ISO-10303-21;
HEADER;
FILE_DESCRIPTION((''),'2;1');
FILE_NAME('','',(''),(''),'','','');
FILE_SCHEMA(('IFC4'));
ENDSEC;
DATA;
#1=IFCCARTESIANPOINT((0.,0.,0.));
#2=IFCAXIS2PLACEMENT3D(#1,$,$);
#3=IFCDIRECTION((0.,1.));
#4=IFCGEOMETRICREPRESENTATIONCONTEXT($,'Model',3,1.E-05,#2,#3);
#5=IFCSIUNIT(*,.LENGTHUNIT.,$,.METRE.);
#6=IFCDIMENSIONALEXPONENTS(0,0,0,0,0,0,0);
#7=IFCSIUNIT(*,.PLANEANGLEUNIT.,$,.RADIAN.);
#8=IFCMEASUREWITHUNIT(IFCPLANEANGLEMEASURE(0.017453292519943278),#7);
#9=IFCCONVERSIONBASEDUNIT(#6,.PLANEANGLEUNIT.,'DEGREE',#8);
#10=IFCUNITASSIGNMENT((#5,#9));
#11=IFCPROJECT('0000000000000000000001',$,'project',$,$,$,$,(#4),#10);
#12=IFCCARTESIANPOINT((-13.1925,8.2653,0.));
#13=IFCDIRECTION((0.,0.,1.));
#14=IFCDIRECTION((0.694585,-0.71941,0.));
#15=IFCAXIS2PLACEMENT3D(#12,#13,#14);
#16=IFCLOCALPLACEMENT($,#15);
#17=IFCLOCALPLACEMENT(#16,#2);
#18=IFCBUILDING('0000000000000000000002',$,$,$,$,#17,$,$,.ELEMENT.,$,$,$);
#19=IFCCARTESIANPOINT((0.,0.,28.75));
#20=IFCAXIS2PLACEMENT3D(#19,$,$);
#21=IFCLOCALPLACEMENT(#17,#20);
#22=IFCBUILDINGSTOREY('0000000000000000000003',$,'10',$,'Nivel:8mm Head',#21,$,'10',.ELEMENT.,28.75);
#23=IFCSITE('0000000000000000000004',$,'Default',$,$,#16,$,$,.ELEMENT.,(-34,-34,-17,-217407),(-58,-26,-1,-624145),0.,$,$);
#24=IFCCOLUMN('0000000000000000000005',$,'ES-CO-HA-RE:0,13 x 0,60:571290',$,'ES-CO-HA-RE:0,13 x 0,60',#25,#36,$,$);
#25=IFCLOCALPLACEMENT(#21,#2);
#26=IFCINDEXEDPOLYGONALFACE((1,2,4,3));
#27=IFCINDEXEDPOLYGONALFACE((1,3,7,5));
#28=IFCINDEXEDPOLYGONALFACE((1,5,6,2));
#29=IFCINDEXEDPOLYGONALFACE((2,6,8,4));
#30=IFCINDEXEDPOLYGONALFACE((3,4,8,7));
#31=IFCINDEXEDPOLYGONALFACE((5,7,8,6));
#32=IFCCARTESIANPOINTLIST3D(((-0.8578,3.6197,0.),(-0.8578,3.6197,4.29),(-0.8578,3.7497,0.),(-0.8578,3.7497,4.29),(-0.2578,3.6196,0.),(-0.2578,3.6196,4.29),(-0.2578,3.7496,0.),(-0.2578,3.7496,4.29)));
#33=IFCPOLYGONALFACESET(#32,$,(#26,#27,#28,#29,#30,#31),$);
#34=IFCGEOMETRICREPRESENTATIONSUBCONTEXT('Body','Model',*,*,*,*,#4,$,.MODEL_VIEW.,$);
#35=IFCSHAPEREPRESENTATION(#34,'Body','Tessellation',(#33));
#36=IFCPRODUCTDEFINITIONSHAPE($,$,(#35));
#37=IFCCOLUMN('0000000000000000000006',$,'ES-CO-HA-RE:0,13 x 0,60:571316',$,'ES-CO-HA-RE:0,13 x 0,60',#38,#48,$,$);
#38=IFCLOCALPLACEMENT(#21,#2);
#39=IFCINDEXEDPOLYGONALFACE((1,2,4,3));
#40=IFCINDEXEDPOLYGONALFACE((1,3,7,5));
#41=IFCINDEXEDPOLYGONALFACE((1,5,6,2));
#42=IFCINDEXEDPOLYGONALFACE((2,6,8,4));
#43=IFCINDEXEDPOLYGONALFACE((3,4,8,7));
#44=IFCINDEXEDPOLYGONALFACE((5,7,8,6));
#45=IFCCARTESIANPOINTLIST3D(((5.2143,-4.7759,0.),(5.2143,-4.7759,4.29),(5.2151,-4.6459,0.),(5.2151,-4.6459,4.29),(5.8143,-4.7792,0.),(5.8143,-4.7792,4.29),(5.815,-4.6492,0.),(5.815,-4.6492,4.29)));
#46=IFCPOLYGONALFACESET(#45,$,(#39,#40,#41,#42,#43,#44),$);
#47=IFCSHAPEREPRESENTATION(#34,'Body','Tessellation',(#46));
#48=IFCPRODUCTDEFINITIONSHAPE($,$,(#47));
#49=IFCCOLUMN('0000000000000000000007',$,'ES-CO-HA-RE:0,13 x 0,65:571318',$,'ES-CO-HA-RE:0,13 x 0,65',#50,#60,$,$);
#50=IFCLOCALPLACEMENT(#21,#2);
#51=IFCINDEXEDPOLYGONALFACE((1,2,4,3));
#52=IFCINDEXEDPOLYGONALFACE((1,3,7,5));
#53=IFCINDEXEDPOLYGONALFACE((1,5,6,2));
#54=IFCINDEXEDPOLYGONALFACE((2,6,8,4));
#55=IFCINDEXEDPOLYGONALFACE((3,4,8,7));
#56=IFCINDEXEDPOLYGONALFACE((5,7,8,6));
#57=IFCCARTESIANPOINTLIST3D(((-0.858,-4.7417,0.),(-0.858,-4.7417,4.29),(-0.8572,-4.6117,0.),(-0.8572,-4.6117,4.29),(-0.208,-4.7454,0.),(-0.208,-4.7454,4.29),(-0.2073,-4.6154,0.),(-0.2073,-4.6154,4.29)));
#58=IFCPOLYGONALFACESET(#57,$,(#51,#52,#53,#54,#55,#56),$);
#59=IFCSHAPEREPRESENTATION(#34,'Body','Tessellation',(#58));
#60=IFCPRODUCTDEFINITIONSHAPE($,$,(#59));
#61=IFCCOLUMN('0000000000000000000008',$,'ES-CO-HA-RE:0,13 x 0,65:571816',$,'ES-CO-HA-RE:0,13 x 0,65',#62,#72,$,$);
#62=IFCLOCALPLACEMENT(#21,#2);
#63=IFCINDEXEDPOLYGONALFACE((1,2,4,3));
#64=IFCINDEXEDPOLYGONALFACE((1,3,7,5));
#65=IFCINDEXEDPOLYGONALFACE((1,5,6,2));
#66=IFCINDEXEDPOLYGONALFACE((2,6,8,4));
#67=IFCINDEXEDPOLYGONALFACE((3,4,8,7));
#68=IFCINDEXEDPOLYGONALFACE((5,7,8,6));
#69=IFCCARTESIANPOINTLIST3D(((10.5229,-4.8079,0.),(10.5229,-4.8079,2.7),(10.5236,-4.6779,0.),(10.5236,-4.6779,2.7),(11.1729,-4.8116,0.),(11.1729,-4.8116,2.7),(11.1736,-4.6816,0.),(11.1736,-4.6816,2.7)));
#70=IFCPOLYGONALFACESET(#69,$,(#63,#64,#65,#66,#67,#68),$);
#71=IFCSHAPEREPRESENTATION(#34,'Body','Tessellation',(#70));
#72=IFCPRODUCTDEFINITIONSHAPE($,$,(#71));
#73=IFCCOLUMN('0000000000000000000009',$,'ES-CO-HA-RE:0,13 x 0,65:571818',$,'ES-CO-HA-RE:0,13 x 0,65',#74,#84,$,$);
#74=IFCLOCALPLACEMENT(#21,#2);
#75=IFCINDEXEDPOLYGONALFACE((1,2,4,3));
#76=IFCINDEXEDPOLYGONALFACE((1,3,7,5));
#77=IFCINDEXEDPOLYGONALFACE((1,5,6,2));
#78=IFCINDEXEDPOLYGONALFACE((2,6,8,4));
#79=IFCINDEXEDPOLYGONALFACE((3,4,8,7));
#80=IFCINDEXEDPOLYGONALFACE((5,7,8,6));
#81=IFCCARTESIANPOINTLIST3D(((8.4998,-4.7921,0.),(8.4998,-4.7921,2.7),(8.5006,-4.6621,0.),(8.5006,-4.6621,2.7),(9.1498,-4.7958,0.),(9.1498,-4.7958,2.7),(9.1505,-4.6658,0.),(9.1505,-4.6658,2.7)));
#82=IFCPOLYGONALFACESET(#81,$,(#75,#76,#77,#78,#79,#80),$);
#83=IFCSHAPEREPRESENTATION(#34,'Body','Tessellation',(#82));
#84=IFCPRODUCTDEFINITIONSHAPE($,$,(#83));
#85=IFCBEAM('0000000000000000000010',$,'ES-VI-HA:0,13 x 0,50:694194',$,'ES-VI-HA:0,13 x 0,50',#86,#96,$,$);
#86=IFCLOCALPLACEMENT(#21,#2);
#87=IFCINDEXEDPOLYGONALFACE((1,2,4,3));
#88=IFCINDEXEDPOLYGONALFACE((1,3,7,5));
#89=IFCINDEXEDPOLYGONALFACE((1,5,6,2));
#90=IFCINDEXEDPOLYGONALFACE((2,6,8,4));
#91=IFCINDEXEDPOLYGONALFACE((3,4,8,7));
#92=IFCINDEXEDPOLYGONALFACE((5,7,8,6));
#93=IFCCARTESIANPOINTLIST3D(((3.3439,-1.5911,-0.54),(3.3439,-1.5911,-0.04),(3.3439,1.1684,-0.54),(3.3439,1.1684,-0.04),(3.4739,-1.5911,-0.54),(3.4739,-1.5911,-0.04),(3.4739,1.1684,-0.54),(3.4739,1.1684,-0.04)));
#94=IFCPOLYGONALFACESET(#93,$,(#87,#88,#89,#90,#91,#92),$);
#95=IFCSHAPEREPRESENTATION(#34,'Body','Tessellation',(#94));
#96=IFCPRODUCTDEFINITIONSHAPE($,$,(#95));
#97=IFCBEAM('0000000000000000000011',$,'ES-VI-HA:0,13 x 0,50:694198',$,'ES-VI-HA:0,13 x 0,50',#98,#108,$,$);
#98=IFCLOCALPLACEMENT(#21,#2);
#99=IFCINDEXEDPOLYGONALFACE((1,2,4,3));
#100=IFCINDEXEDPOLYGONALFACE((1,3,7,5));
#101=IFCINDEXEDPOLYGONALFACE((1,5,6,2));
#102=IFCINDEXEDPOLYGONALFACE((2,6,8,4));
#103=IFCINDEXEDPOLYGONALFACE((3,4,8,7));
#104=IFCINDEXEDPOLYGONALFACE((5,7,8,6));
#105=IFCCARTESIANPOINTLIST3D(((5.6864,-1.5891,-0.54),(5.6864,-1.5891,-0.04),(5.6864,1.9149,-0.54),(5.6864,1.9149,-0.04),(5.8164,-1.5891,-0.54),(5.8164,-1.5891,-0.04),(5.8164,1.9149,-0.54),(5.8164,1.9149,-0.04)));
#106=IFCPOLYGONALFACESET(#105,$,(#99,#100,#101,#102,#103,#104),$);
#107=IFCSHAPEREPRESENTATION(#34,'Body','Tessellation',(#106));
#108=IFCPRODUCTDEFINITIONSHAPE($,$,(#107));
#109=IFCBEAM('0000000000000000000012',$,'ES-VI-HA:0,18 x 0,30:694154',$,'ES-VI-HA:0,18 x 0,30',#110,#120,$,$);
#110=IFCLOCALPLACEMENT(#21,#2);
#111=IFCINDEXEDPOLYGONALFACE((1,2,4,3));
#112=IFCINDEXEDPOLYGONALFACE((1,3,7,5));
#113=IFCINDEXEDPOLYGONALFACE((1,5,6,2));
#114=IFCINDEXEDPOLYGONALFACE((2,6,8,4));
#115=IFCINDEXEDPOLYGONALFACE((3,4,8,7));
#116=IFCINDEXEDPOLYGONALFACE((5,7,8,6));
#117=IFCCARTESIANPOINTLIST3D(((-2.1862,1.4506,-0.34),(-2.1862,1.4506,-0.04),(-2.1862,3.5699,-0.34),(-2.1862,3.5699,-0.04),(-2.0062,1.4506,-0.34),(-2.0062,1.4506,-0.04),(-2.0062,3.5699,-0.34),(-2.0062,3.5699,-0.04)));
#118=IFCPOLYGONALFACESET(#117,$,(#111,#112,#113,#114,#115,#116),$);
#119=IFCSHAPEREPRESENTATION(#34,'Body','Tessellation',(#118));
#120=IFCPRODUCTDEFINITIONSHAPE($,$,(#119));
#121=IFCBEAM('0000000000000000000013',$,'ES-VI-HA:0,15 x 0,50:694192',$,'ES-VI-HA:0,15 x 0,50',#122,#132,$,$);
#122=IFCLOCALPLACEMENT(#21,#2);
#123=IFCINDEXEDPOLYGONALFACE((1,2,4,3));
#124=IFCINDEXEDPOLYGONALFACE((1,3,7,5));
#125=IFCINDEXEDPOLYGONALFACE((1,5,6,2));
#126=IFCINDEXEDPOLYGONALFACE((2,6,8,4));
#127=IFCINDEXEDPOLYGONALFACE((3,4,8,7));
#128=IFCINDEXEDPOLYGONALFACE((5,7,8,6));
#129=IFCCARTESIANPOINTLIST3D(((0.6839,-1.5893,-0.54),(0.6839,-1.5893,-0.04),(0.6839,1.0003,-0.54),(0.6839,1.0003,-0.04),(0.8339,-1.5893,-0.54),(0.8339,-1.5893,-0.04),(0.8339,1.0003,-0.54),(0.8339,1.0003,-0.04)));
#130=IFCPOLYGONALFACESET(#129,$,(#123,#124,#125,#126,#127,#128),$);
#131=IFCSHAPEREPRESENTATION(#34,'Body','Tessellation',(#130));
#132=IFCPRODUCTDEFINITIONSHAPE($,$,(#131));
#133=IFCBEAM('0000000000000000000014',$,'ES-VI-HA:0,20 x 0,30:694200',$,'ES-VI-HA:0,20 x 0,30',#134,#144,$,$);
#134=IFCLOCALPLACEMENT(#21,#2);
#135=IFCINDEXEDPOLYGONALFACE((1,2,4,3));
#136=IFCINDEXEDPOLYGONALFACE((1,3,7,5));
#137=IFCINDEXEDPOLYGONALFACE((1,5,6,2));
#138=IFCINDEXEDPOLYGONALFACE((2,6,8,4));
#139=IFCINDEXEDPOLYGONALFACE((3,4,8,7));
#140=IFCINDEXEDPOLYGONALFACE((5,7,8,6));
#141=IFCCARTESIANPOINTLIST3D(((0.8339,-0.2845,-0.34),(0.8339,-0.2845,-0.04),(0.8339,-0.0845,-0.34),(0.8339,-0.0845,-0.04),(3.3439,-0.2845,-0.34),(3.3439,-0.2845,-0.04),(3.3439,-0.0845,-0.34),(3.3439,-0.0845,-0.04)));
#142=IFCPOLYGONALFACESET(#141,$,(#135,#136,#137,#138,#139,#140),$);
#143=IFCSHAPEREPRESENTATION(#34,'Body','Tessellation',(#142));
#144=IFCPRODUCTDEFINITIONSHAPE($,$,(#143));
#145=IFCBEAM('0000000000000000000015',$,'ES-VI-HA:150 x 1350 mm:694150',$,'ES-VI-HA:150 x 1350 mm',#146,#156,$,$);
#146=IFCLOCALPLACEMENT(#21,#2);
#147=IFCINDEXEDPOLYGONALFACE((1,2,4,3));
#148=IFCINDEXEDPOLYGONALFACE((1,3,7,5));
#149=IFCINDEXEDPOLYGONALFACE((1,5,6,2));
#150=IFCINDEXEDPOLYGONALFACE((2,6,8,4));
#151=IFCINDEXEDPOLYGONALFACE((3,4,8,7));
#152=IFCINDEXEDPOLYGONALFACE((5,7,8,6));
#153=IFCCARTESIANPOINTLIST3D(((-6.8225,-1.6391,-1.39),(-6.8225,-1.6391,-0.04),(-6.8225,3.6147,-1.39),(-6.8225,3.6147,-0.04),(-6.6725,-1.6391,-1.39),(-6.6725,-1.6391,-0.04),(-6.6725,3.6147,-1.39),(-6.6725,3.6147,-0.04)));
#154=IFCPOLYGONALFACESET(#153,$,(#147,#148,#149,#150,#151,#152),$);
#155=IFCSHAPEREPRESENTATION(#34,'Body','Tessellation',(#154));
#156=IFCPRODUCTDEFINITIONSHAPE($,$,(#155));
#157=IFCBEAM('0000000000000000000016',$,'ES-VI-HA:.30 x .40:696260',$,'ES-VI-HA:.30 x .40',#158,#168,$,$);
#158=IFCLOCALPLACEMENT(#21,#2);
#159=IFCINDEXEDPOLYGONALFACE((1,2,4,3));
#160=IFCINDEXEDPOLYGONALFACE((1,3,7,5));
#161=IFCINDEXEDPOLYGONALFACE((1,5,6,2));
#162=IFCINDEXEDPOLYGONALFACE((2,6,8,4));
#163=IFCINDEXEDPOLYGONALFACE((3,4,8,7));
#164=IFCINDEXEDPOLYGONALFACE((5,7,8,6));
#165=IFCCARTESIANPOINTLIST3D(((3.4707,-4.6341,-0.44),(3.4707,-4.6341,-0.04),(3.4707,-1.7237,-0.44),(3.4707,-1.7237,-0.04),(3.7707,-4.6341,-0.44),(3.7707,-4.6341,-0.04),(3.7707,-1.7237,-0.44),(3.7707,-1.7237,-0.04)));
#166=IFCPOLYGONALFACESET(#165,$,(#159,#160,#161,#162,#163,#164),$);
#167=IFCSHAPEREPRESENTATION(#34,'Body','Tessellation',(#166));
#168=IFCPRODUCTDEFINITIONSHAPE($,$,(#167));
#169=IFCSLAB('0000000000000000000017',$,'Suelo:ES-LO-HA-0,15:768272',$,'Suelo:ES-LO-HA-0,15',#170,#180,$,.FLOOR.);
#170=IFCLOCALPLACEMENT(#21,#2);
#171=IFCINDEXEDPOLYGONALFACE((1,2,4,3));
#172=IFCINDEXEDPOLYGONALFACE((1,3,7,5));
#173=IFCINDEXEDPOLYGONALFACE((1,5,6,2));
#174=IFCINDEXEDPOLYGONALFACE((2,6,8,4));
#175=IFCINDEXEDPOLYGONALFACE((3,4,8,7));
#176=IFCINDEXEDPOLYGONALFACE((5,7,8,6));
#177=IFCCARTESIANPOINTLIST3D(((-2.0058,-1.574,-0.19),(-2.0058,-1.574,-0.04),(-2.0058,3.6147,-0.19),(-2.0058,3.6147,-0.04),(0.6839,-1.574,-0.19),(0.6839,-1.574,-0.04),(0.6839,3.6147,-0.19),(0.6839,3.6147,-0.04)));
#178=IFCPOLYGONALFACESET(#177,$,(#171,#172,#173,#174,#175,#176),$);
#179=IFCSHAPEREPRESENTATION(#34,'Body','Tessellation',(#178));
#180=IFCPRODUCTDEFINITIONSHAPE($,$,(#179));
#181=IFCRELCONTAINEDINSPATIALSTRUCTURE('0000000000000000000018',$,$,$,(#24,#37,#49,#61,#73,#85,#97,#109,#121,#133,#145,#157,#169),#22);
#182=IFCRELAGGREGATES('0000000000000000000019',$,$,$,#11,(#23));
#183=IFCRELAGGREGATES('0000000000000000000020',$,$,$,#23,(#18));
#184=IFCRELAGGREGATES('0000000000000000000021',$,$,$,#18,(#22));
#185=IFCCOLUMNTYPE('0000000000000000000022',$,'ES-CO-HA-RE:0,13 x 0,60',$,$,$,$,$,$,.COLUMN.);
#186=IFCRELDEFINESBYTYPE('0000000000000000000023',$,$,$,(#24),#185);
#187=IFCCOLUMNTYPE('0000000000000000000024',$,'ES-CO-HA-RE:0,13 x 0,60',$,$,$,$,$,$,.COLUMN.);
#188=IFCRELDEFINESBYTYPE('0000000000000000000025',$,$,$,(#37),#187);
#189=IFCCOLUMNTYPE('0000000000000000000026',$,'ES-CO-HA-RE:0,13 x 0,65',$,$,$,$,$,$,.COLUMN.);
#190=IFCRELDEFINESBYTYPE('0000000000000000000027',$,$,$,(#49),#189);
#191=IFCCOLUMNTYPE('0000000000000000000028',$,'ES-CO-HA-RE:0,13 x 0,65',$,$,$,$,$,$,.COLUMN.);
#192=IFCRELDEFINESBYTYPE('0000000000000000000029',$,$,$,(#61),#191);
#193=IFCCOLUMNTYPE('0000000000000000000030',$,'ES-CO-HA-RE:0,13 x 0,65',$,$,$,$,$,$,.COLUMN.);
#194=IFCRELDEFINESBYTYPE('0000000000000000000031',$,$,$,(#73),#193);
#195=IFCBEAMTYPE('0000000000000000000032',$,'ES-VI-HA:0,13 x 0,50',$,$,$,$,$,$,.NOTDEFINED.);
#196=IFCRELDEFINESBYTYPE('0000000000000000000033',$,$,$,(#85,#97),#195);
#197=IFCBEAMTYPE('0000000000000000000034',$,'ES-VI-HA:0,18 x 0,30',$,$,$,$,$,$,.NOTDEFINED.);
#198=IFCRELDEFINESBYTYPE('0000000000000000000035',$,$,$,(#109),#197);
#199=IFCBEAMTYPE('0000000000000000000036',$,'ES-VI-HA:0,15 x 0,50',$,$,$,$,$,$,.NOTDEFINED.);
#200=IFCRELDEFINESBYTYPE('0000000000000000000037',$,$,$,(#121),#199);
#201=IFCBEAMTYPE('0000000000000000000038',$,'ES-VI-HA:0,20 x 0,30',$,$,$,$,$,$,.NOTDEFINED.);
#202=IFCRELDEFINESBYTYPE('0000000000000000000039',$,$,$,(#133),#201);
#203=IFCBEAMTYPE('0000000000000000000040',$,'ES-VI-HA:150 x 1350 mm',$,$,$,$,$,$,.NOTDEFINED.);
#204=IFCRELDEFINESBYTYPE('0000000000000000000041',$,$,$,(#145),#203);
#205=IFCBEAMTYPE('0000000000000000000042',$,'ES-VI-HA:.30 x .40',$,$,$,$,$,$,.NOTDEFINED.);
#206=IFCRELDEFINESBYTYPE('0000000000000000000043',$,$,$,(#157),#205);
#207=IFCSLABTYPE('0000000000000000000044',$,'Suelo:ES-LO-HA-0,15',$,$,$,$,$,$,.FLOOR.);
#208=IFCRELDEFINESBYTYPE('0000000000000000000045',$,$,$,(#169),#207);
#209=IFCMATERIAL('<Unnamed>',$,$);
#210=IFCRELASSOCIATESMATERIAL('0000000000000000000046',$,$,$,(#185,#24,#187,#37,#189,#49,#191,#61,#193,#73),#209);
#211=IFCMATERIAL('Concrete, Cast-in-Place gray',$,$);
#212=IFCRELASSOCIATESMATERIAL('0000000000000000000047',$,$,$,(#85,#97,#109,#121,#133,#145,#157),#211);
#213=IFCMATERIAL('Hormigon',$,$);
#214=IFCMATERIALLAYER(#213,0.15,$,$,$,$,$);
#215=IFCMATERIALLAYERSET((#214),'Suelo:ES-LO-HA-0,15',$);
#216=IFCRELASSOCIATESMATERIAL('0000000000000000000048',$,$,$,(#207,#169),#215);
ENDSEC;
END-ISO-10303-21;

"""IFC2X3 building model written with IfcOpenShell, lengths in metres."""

from ifc_helpers import new_model, entity, si_unit, converted_unit, direction, frame, frame_2d, origin, origin_2d_with_axis, place, context, subcontext, project, spatial, rectangle, extrude, source, transform, mapped, material, layer, layer_set, layer_usage, type_object, type_shapes, element, save


model = new_model("IFC2X3")

# Units and contexts
model_context = context("Model", 3, precision=1e-05, world=origin(), true_north=direction((0.0, 1.0)))
body_context = subcontext(model_context, "Body", "Model", "MODEL_VIEW")
ifc_project = project(units=[si_unit("LENGTHUNIT", "METRE"), converted_unit("PLANEANGLEUNIT", "DEGREE", entity("IfcPlaneAngleMeasure", 0.017453292519943278), si_unit("PLANEANGLEUNIT", "RADIAN"), dimensions=[0, 0, 0, 0, 0, 0, 0])], contexts=[model_context])

# Site, building, storey
site_placement = place(None, frame((-13.1925, 8.2653, 0.0), z_axis=(0.0, 0.0, 1.0), x_axis=(0.694585, -0.71941, 0.0)))
site = spatial("IfcSite", under=ifc_project, at=site_placement, Name="Default", CompositionType="ELEMENT", RefLatitude=(-34, -34, -17, -217407), RefLongitude=(-58, -26, -1, -624145), RefElevation=0.0)
building_placement = place(site_placement, origin())
building = spatial("IfcBuilding", under=site, at=building_placement, CompositionType="ELEMENT")
storey_placement = place(building_placement, frame((0.0, 0.0, 28.75)))
storey = spatial("IfcBuildingStorey", under=building, at=storey_placement, Name="10", ObjectType="Nivel:8mm Head", LongName="10", CompositionType="ELEMENT", Elevation=28.75)

# Columns
ifc_material_1 = material(Name="<Unnamed>")
column_type_1 = type_object("IfcColumnType", Name="ES-CO-HA-RE:0,13 x 0,60", PredefinedType="COLUMN", material=ifc_material_1)
shared_shape_1 = source(origin(), body_context, "Body", "SweptSolid", [
    extrude(rectangle(XDim=0.6, YDim=0.13, at=frame_2d((0.0, 0.0), x_axis=(1.0, 0.0))), frame((-0.5578, 3.6847, 28.75), z_axis=(0.0, 0.0, 1.0), x_axis=(-1.0, 0.000006, 0.0)), (0.0, 0.0, 1.0), 4.29),
])
type_shapes(column_type_1, [shared_shape_1])
column_1_placement = place(storey_placement, frame((0.0, 0.0, -28.75)))
element("IfcColumn", 1, at=column_1_placement, inside=storey, type_object=column_type_1, material=ifc_material_1, Name="ES-CO-HA-RE:0,13 x 0,60:571290", ObjectType="ES-CO-HA-RE:0,13 x 0,60", context=body_context, shape_type="MappedRepresentation", body=[
    mapped(shared_shape_1, transform((0.0, 0.0, 0.0), scale=1.0)),
])
column_type_2 = type_object("IfcColumnType", Name="ES-CO-HA-RE:0,13 x 0,60", PredefinedType="COLUMN", material=ifc_material_1)
shared_shape_2 = source(origin(), body_context, "Body", "SweptSolid", [
    extrude(rectangle(XDim=0.6, YDim=0.13, at=frame_2d((0.0, 0.0), x_axis=(1.0, 0.0))), frame((5.5147, -4.7125, 28.75), z_axis=(0.0, 0.0, 1.0), x_axis=(-0.999984, 0.005619, 0.0)), (0.0, 0.0, 1.0), 4.29),
])
type_shapes(column_type_2, [shared_shape_2])
column_2_placement = place(storey_placement, frame((0.0, 0.0, -28.75)))
element("IfcColumn", 2, at=column_2_placement, inside=storey, type_object=column_type_2, material=ifc_material_1, Name="ES-CO-HA-RE:0,13 x 0,60:571316", ObjectType="ES-CO-HA-RE:0,13 x 0,60", context=body_context, shape_type="MappedRepresentation", body=[
    mapped(shared_shape_2, transform((0.0, 0.0, 0.0), scale=1.0)),
])
column_type_3 = type_object("IfcColumnType", Name="ES-CO-HA-RE:0,13 x 0,65", PredefinedType="COLUMN", material=ifc_material_1)
shared_shape_3 = source(origin(), body_context, "Body", "SweptSolid", [
    extrude(rectangle(XDim=0.65, YDim=0.13, at=frame_2d((0.0, 0.0), x_axis=(1.0, 0.0))), frame((-0.5326, -4.6786, 28.75), z_axis=(0.0, 0.0, 1.0), x_axis=(-0.999984, 0.005617, 0.0)), (0.0, 0.0, 1.0), 4.29),
])
type_shapes(column_type_3, [shared_shape_3])
column_3_placement = place(storey_placement, frame((0.0, 0.0, -28.75)))
element("IfcColumn", 3, at=column_3_placement, inside=storey, type_object=column_type_3, material=ifc_material_1, Name="ES-CO-HA-RE:0,13 x 0,65:571318", ObjectType="ES-CO-HA-RE:0,13 x 0,65", context=body_context, shape_type="MappedRepresentation", body=[
    mapped(shared_shape_3, transform((0.0, 0.0, 0.0), scale=1.0)),
])
column_type_4 = type_object("IfcColumnType", Name="ES-CO-HA-RE:0,13 x 0,65", PredefinedType="COLUMN", material=ifc_material_1)
shared_shape_4 = source(origin(), body_context, "Body", "SweptSolid", [
    extrude(rectangle(XDim=0.65, YDim=0.13, at=frame_2d((0.0, 0.0), x_axis=(1.0, 0.0))), frame((10.8483, -4.7447, 28.75), z_axis=(0.0, 0.0, 1.0), x_axis=(-0.999984, 0.005619, 0.0)), (0.0, 0.0, 1.0), 2.7),
])
type_shapes(column_type_4, [shared_shape_4])
column_4_placement = place(storey_placement, frame((0.0, 0.0, -28.75)))
element("IfcColumn", 4, at=column_4_placement, inside=storey, type_object=column_type_4, material=ifc_material_1, Name="ES-CO-HA-RE:0,13 x 0,65:571816", ObjectType="ES-CO-HA-RE:0,13 x 0,65", context=body_context, shape_type="MappedRepresentation", body=[
    mapped(shared_shape_4, transform((0.0, 0.0, 0.0), scale=1.0)),
])
column_type_5 = type_object("IfcColumnType", Name="ES-CO-HA-RE:0,13 x 0,65", PredefinedType="COLUMN", material=ifc_material_1)
shared_shape_5 = source(origin(), body_context, "Body", "SweptSolid", [
    extrude(rectangle(XDim=0.65, YDim=0.13, at=origin_2d_with_axis()), frame((8.8252, -4.7289, 28.75), z_axis=(0.0, 0.0, 1.0), x_axis=(-0.999984, 0.005619, 0.0)), (0.0, 0.0, 1.0), 2.7),
])
type_shapes(column_type_5, [shared_shape_5])
column_5_placement = place(storey_placement, frame((0.0, 0.0, -28.75)))
element("IfcColumn", 5, at=column_5_placement, inside=storey, type_object=column_type_5, material=ifc_material_1, Name="ES-CO-HA-RE:0,13 x 0,65:571818", ObjectType="ES-CO-HA-RE:0,13 x 0,65", context=body_context, shape_type="MappedRepresentation", body=[
    mapped(shared_shape_5, transform((0.0, 0.0, 0.0), scale=1.0)),
])

# Beams
ifc_material_2 = material(Name="Concrete, Cast-in-Place gray")
beam_type_1 = type_object("IfcBeamType", Name="ES-VI-HA:0,13 x 0,50", PredefinedType="NOTDEFINED")
beam_1_placement = place(storey_placement, frame((3.4089, -1.5916, -0.04), z_axis=(0.0, 0.0, 1.0), x_axis=(0.0, 1.0, 0.0)))
element("IfcBeam", 6, at=beam_1_placement, inside=storey, type_object=beam_type_1, material=ifc_material_2, Name="ES-VI-HA:0,13 x 0,50:694194", ObjectType="ES-VI-HA:0,13 x 0,50", context=body_context, shape_type="SweptSolid", body=[
    extrude(rectangle(XDim=0.5, YDim=0.13, at=frame_2d((0.0, 0.0), x_axis=(1.0, 0.0))), frame((0.0005, 0.0, -0.25), z_axis=(1.0, 0.0, 0.0), x_axis=(0.0, 0.0, -1.0)), (0.0, 0.0, 1.0), 2.7595),
])
beam_2_placement = place(storey_placement, frame((5.7514, -1.5891, -0.04), z_axis=(0.0, 0.0, 1.0), x_axis=(0.0, 1.0, 0.0)))
element("IfcBeam", 7, at=beam_2_placement, inside=storey, type_object=beam_type_1, material=ifc_material_2, Name="ES-VI-HA:0,13 x 0,50:694198", ObjectType="ES-VI-HA:0,13 x 0,50", context=body_context, shape_type="SweptSolid", body=[
    extrude(rectangle(XDim=0.5, YDim=0.13, at=frame_2d((0.0, 0.0), x_axis=(1.0, 0.0))), frame((0.0, 0.0, -0.25), z_axis=(1.0, 0.0, 0.0), x_axis=(0.0, 0.0, -1.0)), (0.0, 0.0, 1.0), 3.5039),
])
beam_type_2 = type_object("IfcBeamType", Name="ES-VI-HA:0,18 x 0,30", PredefinedType="NOTDEFINED")
beam_3_placement = place(storey_placement, frame((-2.0962, 3.5699, -0.04), z_axis=(0.0, 0.0, 1.0), x_axis=(0.0, -1.0, 0.0)))
element("IfcBeam", 8, at=beam_3_placement, inside=storey, type_object=beam_type_2, material=ifc_material_2, Name="ES-VI-HA:0,18 x 0,30:694154", ObjectType="ES-VI-HA:0,18 x 0,30", context=body_context, shape_type="SweptSolid", body=[
    extrude(rectangle(XDim=0.3, YDim=0.18, at=origin_2d_with_axis()), frame((0.0, 0.0, -0.15), z_axis=(1.0, 0.0, 0.0), x_axis=(0.0, 0.0, -1.0)), (0.0, 0.0, 1.0), 2.1193),
])
beam_type_3 = type_object("IfcBeamType", Name="ES-VI-HA:0,15 x 0,50", PredefinedType="NOTDEFINED")
beam_4_placement = place(storey_placement, frame((0.7589, -1.6543, -0.04), z_axis=(0.0, 0.0, 1.0), x_axis=(0.0, 1.0, 0.0)))
element("IfcBeam", 9, at=beam_4_placement, inside=storey, type_object=beam_type_3, material=ifc_material_2, Name="ES-VI-HA:0,15 x 0,50:694192", ObjectType="ES-VI-HA:0,15 x 0,50", context=body_context, shape_type="SweptSolid", body=[
    extrude(rectangle(XDim=0.5, YDim=0.15, at=frame_2d((0.0, 0.0), x_axis=(1.0, 0.0))), frame((0.065, 0.0, -0.25), z_axis=(1.0, 0.0, 0.0), x_axis=(0.0, 0.0, -1.0)), (0.0, 0.0, 1.0), 2.5896),
])
beam_type_4 = type_object("IfcBeamType", Name="ES-VI-HA:0,20 x 0,30", PredefinedType="NOTDEFINED")
beam_5_placement = place(storey_placement, frame((0.7589, -0.1845, -0.04)))
element("IfcBeam", 10, at=beam_5_placement, inside=storey, type_object=beam_type_4, material=ifc_material_2, Name="ES-VI-HA:0,20 x 0,30:694200", ObjectType="ES-VI-HA:0,20 x 0,30", context=body_context, shape_type="SweptSolid", body=[
    extrude(rectangle(XDim=0.3, YDim=0.2, at=frame_2d((0.0, 0.0), x_axis=(1.0, 0.0))), frame((0.075, 0.0, -0.15), z_axis=(1.0, 0.0, 0.0), x_axis=(0.0, 0.0, -1.0)), (0.0, 0.0, 1.0), 2.51),
])
beam_type_5 = type_object("IfcBeamType", Name="ES-VI-HA:150 x 1350 mm", PredefinedType="NOTDEFINED")
beam_6_placement = place(storey_placement, frame((-6.7475, -1.6391, -0.04), z_axis=(0.0, 0.0, 1.0), x_axis=(0.0, 1.0, 0.0)))
element("IfcBeam", 11, at=beam_6_placement, inside=storey, type_object=beam_type_5, material=ifc_material_2, Name="ES-VI-HA:150 x 1350 mm:694150", ObjectType="ES-VI-HA:150 x 1350 mm", context=body_context, shape_type="SweptSolid", body=[
    extrude(rectangle(XDim=1.35, YDim=0.15, at=frame_2d((0.0, 0.0), x_axis=(1.0, 0.0))), frame((0.0, 0.0, -0.675), z_axis=(1.0, 0.0, 0.0), x_axis=(0.0, 0.0, -1.0)), (0.0, 0.0, 1.0), 5.2537),
])
beam_type_6 = type_object("IfcBeamType", Name="ES-VI-HA:.30 x .40", PredefinedType="NOTDEFINED")
beam_7_placement = place(storey_placement, frame((3.6207, -4.7011, -0.04), z_axis=(0.0, 0.0, 1.0), x_axis=(0.0, 1.0, 0.0)))
element("IfcBeam", 12, at=beam_7_placement, inside=storey, type_object=beam_type_6, material=ifc_material_2, Name="ES-VI-HA:.30 x .40:696260", ObjectType="ES-VI-HA:.30 x .40", context=body_context, shape_type="SweptSolid", body=[
    extrude(rectangle(XDim=0.4, YDim=0.3, at=frame_2d((0.0, 0.0), x_axis=(1.0, 0.0))), frame((0.067, 0.0, -0.2), z_axis=(1.0, 0.0, 0.0), x_axis=(0.0, 0.0, -1.0)), (0.0, 0.0, 1.0), 2.9104),
])

# Slab
ifc_material_3 = material(Name="Hormigon")
ifc_layer_1 = layer(ifc_material_3, 0.15)
ifc_layer_set_1 = layer_set([ifc_layer_1], Name="Suelo:ES-LO-HA-0,15")
slab_type = type_object("IfcSlabType", Name="Suelo:ES-LO-HA-0,15", PredefinedType="FLOOR", material=ifc_layer_set_1)
ifc_layer_usage_1 = layer_usage(ifc_layer_set_1, "AXIS3", "POSITIVE", 0.0)
slab_1_placement = place(storey_placement, origin())
element("IfcSlab", 13, at=slab_1_placement, inside=storey, type_object=slab_type, material=ifc_layer_usage_1, Name="Suelo:ES-LO-HA-0,15:768272", ObjectType="Suelo:ES-LO-HA-0,15", PredefinedType="FLOOR", context=body_context, shape_type="SweptSolid", body=[
    extrude(rectangle(XDim=5.1887, YDim=2.6897, at=origin_2d_with_axis()), frame((-0.6609, 1.0203, -0.04), z_axis=(0.0, 0.0, -1.0), x_axis=(0.0, 1.0, 0.0)), (0.0, 0.0, 1.0), 0.15),
])

save(model, "model.ifc")
